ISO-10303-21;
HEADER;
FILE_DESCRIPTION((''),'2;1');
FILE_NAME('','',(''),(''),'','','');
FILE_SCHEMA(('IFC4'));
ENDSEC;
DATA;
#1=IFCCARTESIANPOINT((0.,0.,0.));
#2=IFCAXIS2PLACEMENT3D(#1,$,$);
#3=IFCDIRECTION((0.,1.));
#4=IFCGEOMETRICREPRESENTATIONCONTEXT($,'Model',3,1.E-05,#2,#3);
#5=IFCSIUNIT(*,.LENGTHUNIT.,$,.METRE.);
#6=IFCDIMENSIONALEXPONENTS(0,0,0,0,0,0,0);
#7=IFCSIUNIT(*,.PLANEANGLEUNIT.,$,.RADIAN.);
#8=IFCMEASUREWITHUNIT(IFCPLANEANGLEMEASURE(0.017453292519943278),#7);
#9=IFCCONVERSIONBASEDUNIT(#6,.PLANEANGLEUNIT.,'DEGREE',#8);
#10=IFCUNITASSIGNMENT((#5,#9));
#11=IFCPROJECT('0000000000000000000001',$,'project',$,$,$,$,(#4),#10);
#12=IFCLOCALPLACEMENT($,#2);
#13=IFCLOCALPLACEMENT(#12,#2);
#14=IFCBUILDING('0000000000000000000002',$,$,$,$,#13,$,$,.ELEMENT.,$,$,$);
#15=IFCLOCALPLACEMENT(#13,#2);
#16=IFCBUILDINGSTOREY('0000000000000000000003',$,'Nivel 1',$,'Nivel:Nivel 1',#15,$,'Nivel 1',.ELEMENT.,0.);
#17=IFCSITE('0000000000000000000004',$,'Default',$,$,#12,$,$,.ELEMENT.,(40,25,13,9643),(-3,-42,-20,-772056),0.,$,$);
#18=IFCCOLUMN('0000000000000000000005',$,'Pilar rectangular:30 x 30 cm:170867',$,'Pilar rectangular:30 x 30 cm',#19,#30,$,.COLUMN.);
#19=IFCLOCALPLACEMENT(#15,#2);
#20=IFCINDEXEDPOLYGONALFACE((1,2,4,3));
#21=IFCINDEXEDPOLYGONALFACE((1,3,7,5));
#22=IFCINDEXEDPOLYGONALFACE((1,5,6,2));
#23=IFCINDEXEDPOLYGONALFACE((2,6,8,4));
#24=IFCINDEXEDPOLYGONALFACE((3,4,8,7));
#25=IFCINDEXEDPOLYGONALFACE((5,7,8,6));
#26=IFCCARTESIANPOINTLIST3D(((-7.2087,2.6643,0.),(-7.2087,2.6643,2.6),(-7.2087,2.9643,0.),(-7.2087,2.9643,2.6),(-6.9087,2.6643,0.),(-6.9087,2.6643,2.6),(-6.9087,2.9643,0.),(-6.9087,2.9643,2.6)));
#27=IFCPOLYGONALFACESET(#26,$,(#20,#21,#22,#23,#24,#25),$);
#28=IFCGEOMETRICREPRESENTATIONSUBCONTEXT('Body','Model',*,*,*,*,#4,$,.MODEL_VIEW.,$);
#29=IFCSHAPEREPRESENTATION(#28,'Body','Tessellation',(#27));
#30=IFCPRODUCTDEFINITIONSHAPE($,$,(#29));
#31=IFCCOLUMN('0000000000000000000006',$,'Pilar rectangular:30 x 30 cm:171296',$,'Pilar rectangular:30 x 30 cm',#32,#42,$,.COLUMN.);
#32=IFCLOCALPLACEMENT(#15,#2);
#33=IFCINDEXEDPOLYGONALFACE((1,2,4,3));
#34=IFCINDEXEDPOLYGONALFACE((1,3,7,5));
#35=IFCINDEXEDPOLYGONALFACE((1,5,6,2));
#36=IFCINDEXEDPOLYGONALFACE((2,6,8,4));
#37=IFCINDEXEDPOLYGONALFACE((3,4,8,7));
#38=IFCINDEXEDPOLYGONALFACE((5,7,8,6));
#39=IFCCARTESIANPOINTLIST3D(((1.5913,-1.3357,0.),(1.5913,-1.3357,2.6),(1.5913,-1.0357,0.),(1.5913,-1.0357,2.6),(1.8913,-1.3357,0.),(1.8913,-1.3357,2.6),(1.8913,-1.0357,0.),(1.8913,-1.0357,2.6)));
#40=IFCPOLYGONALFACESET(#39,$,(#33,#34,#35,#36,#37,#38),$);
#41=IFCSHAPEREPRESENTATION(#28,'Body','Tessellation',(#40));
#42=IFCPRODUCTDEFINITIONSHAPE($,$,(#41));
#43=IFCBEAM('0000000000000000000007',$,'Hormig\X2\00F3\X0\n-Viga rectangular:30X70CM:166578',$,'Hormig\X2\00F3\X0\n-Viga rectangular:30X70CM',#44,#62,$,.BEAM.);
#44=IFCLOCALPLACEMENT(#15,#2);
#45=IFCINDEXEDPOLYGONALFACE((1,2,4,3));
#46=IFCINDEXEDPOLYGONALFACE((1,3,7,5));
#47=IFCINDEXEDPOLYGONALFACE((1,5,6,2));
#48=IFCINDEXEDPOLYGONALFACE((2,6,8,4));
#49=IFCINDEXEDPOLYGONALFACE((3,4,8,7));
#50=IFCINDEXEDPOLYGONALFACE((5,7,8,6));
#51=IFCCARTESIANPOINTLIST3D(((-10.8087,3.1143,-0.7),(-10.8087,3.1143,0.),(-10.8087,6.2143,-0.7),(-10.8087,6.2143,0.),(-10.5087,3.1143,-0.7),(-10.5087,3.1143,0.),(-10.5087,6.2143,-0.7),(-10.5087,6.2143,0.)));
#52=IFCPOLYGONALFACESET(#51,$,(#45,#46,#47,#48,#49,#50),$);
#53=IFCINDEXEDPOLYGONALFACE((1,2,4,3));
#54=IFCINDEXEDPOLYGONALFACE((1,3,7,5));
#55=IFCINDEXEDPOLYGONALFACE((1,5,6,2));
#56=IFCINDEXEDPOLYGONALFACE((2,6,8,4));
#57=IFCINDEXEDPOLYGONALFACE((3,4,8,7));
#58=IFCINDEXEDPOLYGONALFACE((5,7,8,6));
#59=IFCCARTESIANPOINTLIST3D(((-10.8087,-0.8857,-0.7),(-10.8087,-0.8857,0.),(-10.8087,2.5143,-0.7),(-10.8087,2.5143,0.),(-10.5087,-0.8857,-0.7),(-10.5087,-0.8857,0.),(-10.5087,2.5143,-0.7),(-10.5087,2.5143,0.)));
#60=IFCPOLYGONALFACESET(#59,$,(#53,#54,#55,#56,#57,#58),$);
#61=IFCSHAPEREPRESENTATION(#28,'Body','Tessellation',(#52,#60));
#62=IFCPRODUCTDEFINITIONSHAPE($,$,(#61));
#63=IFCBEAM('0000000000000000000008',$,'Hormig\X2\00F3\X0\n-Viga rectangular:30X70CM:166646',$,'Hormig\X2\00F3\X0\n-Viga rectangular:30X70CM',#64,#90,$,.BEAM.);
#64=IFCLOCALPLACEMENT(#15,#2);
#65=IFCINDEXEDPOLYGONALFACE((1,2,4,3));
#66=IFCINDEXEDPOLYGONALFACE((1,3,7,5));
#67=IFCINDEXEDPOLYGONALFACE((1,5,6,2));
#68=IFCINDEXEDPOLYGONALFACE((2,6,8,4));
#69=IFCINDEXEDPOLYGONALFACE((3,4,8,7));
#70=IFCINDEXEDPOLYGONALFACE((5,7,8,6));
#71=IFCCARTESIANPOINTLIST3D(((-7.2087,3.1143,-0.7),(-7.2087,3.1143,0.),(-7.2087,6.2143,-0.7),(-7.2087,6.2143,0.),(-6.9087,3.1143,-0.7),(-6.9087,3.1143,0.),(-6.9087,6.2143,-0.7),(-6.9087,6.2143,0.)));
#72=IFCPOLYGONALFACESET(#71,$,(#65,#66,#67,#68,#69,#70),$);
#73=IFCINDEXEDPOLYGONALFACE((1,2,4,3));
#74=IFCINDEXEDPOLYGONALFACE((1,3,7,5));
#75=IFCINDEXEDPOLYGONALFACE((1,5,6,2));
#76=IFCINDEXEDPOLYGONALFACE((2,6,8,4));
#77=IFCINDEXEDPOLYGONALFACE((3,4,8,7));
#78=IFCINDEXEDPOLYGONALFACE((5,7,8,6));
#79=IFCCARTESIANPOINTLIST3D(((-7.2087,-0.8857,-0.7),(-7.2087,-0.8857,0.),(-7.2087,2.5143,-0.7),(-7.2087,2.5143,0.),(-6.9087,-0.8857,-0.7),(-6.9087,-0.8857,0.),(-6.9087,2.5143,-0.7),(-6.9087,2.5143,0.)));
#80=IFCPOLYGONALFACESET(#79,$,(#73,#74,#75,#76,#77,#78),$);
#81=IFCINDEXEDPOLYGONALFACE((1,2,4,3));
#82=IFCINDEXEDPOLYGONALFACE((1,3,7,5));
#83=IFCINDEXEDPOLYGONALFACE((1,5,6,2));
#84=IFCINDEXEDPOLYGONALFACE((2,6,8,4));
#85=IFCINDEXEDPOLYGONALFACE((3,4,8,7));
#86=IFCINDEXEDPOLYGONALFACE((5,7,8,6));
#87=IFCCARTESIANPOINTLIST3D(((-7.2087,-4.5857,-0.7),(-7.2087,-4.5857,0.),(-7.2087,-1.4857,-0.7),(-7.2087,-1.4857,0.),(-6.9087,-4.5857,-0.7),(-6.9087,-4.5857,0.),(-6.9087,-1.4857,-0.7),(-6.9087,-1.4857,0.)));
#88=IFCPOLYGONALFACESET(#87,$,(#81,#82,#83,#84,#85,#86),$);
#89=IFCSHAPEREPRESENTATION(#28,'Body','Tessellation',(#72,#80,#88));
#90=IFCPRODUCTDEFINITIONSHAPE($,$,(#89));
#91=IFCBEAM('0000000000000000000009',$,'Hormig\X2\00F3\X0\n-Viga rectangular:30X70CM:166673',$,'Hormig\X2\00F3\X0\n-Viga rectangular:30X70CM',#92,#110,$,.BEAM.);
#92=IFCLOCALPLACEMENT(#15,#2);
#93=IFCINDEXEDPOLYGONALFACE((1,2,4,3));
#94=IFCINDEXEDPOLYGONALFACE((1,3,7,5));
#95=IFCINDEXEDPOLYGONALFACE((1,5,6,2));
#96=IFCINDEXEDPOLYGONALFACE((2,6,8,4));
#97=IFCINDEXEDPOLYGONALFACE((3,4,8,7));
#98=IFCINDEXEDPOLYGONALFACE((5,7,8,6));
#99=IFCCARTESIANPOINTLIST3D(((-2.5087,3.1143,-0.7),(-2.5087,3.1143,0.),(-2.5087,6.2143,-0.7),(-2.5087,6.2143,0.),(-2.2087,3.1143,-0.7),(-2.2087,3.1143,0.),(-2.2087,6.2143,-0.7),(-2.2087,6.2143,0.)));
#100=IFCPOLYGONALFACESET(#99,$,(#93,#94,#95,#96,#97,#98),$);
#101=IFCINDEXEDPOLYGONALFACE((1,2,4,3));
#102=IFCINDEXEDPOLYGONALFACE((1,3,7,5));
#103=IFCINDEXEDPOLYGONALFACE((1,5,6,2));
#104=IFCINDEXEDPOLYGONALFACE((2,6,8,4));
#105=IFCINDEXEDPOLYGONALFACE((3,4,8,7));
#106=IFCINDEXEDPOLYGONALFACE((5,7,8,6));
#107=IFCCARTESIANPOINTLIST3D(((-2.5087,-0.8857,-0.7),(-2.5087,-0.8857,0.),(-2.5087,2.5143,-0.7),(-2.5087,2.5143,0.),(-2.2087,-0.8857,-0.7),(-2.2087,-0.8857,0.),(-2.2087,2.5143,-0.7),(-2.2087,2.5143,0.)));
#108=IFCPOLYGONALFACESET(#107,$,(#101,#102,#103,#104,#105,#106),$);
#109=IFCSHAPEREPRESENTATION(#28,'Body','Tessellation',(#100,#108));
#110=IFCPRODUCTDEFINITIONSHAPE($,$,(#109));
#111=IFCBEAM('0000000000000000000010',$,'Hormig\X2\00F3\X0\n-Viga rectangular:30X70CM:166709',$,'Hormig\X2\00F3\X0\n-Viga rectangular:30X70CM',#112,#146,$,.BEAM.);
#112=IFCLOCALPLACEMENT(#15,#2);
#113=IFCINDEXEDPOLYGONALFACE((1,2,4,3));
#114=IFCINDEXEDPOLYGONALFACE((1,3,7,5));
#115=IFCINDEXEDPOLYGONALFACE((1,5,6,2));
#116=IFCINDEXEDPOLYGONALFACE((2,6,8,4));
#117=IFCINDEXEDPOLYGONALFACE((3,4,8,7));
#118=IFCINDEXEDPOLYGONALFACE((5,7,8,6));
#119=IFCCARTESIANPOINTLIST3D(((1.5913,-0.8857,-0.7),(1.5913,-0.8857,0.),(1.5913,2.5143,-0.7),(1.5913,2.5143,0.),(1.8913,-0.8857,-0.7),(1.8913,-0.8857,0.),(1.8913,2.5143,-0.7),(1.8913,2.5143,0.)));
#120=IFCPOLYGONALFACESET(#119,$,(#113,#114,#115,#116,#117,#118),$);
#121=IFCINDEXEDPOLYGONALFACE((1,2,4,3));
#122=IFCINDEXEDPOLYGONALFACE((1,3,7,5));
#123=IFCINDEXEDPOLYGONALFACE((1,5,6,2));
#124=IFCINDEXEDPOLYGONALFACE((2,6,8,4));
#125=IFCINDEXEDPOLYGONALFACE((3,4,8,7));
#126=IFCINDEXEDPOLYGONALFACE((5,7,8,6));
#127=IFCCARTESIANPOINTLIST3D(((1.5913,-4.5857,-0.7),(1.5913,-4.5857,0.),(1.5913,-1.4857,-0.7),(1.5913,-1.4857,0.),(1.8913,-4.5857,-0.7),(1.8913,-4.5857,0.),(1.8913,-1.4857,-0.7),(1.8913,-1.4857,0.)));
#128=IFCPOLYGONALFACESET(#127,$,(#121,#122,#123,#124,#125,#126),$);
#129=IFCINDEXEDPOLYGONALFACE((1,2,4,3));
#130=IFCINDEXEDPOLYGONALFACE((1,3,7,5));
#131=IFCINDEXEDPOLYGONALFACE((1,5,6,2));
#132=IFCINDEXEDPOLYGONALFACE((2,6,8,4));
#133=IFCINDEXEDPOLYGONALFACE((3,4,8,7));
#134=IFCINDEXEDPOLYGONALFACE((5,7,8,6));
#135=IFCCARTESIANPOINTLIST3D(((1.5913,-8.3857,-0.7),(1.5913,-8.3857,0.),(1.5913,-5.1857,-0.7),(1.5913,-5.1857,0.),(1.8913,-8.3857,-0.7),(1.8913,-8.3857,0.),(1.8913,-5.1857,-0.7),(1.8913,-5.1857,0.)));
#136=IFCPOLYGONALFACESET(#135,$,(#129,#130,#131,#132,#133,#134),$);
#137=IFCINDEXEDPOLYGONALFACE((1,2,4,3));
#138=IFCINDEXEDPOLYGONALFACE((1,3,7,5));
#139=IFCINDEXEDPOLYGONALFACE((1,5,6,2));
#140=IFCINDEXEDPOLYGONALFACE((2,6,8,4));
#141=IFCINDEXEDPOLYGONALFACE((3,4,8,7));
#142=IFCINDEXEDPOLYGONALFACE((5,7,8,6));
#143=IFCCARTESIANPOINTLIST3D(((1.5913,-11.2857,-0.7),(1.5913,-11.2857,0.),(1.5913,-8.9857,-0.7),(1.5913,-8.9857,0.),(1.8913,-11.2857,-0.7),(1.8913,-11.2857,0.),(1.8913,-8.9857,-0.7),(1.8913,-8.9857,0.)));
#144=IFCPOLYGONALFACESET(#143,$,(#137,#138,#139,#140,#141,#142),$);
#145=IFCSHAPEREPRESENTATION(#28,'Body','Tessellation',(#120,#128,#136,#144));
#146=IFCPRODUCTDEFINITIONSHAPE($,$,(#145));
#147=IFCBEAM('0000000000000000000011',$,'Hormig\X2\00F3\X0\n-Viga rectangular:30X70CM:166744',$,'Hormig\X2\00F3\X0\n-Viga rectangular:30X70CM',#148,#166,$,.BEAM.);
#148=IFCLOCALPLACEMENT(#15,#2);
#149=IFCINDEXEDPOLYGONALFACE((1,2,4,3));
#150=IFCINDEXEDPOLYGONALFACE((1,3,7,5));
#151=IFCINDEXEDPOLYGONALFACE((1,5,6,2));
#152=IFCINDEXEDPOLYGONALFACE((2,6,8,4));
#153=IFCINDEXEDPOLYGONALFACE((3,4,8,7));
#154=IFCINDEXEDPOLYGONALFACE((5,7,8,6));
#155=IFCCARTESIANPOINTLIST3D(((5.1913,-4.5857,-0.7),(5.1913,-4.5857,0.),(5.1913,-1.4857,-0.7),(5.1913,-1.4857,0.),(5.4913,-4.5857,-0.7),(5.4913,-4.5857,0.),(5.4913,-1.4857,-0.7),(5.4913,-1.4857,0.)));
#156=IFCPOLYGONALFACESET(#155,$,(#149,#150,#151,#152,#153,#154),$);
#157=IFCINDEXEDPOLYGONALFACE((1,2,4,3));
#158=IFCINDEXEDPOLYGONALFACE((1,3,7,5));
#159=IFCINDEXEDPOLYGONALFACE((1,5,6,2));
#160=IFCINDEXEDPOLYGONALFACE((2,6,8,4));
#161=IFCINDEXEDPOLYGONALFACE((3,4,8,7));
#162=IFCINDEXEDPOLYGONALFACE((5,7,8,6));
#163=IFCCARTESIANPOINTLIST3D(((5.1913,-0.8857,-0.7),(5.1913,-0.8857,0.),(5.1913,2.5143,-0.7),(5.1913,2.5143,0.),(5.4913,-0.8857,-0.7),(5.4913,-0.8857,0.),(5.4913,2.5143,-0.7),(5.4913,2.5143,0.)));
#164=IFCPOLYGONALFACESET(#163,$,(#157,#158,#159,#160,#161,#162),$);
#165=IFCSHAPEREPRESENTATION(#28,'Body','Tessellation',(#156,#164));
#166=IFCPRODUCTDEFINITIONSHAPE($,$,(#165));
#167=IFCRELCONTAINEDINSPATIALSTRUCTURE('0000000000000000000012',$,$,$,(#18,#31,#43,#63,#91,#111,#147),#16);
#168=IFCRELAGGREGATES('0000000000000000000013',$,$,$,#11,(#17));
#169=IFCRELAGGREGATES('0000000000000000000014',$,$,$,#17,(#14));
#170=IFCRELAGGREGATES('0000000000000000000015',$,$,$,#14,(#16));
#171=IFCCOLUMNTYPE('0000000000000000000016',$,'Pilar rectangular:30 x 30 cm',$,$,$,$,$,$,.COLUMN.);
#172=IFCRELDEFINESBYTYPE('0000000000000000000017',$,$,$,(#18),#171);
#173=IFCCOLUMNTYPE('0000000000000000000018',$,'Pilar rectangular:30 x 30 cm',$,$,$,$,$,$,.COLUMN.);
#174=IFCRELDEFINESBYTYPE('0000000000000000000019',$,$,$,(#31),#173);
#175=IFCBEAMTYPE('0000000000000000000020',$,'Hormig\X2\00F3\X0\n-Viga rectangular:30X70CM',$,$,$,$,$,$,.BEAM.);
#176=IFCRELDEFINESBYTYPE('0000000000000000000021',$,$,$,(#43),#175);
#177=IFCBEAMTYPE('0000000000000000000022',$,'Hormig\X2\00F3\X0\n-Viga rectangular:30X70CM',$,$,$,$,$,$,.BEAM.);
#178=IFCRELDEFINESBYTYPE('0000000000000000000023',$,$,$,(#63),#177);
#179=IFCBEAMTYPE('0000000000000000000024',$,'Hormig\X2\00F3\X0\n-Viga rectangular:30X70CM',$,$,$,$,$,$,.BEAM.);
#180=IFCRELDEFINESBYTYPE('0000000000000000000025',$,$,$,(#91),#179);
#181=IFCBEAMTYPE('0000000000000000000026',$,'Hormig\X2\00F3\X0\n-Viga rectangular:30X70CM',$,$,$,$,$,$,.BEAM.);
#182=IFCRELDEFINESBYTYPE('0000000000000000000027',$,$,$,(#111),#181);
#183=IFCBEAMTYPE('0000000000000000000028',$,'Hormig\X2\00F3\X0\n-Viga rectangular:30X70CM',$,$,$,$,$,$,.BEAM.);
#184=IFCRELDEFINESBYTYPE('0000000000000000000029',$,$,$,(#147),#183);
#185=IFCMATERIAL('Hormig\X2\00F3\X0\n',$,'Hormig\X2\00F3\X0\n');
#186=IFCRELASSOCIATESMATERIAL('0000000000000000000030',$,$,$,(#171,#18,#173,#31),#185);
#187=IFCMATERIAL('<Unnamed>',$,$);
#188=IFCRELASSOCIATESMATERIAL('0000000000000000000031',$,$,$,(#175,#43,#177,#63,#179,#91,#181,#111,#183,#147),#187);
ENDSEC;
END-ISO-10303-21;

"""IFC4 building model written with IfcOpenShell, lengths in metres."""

from ifc_helpers import new_model, entity, si_unit, converted_unit, direction, frame, origin, place, context, subcontext, project, spatial, indexed_curve, outline, extrude, source, transform, mapped, material, type_object, type_shapes, element, save


model = new_model("IFC4")

# Units and contexts
model_context = context("Model", 3, precision=1e-05, world=origin(), true_north=direction((0.0, 1.0)))
body_context = subcontext(model_context, "Body", "Model", "MODEL_VIEW")
ifc_project = project(units=[si_unit("LENGTHUNIT", "METRE"), converted_unit("PLANEANGLEUNIT", "DEGREE", entity("IfcPlaneAngleMeasure", 0.017453292519943278), si_unit("PLANEANGLEUNIT", "RADIAN"), dimensions=[0, 0, 0, 0, 0, 0, 0])], contexts=[model_context])

# Site, building, storey
site_placement = place(None, origin())
site = spatial("IfcSite", under=ifc_project, at=site_placement, Name="Default", CompositionType="ELEMENT", RefLatitude=(40, 25, 13, 9643), RefLongitude=(-3, -42, -20, -772056), RefElevation=0.0)
building_placement = place(site_placement, origin())
building = spatial("IfcBuilding", under=site, at=building_placement, CompositionType="ELEMENT")
storey_placement = place(building_placement, origin())
storey = spatial("IfcBuildingStorey", under=building, at=storey_placement, Name="Nivel 1", ObjectType="Nivel:Nivel 1", LongName="Nivel 1", CompositionType="ELEMENT", Elevation=0.0)

# Columns
ifc_material_1 = material(Name="Hormigón", Category="Hormigón")
column_type_1 = type_object("IfcColumnType", Name="Pilar rectangular:30 x 30 cm", PredefinedType="COLUMN", material=ifc_material_1)
shared_shape_1 = source(origin(), body_context, "Body", "SweptSolid", [
    extrude(outline(indexed_curve([(-0.15, -0.15), (0.15, -0.15), (0.15, 0.15), (-0.15, 0.15), (-0.15, -0.15)], self_intersect=False)), frame((-7.0587, 2.8143, 0.0), z_axis=(0.0, 0.0, 1.0), x_axis=(-1.0, 0.0, 0.0)), (0.0, 0.0, 1.0), 2.6),
])
type_shapes(column_type_1, [shared_shape_1])
column_1_placement = place(storey_placement, origin())
element("IfcColumn", 1, at=column_1_placement, inside=storey, type_object=column_type_1, material=ifc_material_1, Name="Pilar rectangular:30 x 30 cm:170867", ObjectType="Pilar rectangular:30 x 30 cm", PredefinedType="COLUMN", context=body_context, shape_type="MappedRepresentation", body=[
    mapped(shared_shape_1, transform((0.0, 0.0, 0.0), scale=1.0)),
])
column_type_2 = type_object("IfcColumnType", Name="Pilar rectangular:30 x 30 cm", PredefinedType="COLUMN", material=ifc_material_1)
shared_shape_2 = source(origin(), body_context, "Body", "SweptSolid", [
    extrude(outline(indexed_curve([(-0.15, -0.15), (0.15, -0.15), (0.15, 0.15), (-0.15, 0.15), (-0.15, -0.15)], self_intersect=False)), frame((1.7413, -1.1857, 0.0), z_axis=(0.0, 0.0, 1.0), x_axis=(-1.0, 0.0, 0.0)), (0.0, 0.0, 1.0), 2.6),
])
type_shapes(column_type_2, [shared_shape_2])
column_2_placement = place(storey_placement, origin())
element("IfcColumn", 2, at=column_2_placement, inside=storey, type_object=column_type_2, material=ifc_material_1, Name="Pilar rectangular:30 x 30 cm:171296", ObjectType="Pilar rectangular:30 x 30 cm", PredefinedType="COLUMN", context=body_context, shape_type="MappedRepresentation", body=[
    mapped(shared_shape_2, transform((0.0, 0.0, 0.0), scale=1.0)),
])

# Beams
ifc_material_2 = material(Name="<Unnamed>")
beam_type_1 = type_object("IfcBeamType", Name="Hormigón-Viga rectangular:30X70CM", PredefinedType="BEAM", material=ifc_material_2)
shared_shape_3 = source(origin(), body_context, "Body", "SweptSolid", [
    extrude(outline(indexed_curve([(-0.15, -0.35), (0.15, -0.35), (0.15, 0.35), (-0.15, 0.35), (-0.15, -0.35)], self_intersect=False)), frame((-10.6587, 6.2143, -0.35), z_axis=(0.0, -1.0, 0.0), x_axis=(-1.0, 0.0, 0.0)), (0.0, 0.0, 1.0), 3.1),
    extrude(outline(indexed_curve([(-0.15, -0.35), (0.15, -0.35), (0.15, 0.35), (-0.15, 0.35), (-0.15, -0.35)], self_intersect=False)), frame((-10.6587, 2.5143, -0.35), z_axis=(0.0, -1.0, 0.0), x_axis=(-1.0, 0.0, 0.0)), (0.0, 0.0, 1.0), 3.4),
])
type_shapes(beam_type_1, [shared_shape_3])
beam_1_placement = place(storey_placement, origin())
element("IfcBeam", 3, at=beam_1_placement, inside=storey, type_object=beam_type_1, material=ifc_material_2, Name="Hormigón-Viga rectangular:30X70CM:166578", ObjectType="Hormigón-Viga rectangular:30X70CM", PredefinedType="BEAM", context=body_context, shape_type="MappedRepresentation", body=[
    mapped(shared_shape_3, transform((0.0, 0.0, 0.0), scale=1.0)),
])
beam_type_2 = type_object("IfcBeamType", Name="Hormigón-Viga rectangular:30X70CM", PredefinedType="BEAM", material=ifc_material_2)
shared_shape_4 = source(origin(), body_context, "Body", "SweptSolid", [
    extrude(outline(indexed_curve([(-0.15, -0.35), (0.15, -0.35), (0.15, 0.35), (-0.15, 0.35), (-0.15, -0.35)], self_intersect=False)), frame((-7.0587, 6.2143, -0.35), z_axis=(0.0, -1.0, 0.0), x_axis=(-1.0, 0.0, 0.0)), (0.0, 0.0, 1.0), 3.1),
    extrude(outline(indexed_curve([(-0.15, -0.35), (0.15, -0.35), (0.15, 0.35), (-0.15, 0.35), (-0.15, -0.35)], self_intersect=False)), frame((-7.0587, 2.5143, -0.35), z_axis=(0.0, -1.0, 0.0), x_axis=(-1.0, 0.0, 0.0)), (0.0, 0.0, 1.0), 3.4),
    extrude(outline(indexed_curve([(-0.15, -0.35), (0.15, -0.35), (0.15, 0.35), (-0.15, 0.35), (-0.15, -0.35)], self_intersect=False)), frame((-7.0587, -1.4857, -0.35), z_axis=(0.0, -1.0, 0.0), x_axis=(-1.0, 0.0, 0.0)), (0.0, 0.0, 1.0), 3.1),
])
type_shapes(beam_type_2, [shared_shape_4])
beam_2_placement = place(storey_placement, origin())
element("IfcBeam", 4, at=beam_2_placement, inside=storey, type_object=beam_type_2, material=ifc_material_2, Name="Hormigón-Viga rectangular:30X70CM:166646", ObjectType="Hormigón-Viga rectangular:30X70CM", PredefinedType="BEAM", context=body_context, shape_type="MappedRepresentation", body=[
    mapped(shared_shape_4, transform((0.0, 0.0, 0.0), scale=1.0)),
])
beam_type_3 = type_object("IfcBeamType", Name="Hormigón-Viga rectangular:30X70CM", PredefinedType="BEAM", material=ifc_material_2)
shared_shape_5 = source(origin(), body_context, "Body", "SweptSolid", [
    extrude(outline(indexed_curve([(-0.15, -0.35), (0.15, -0.35), (0.15, 0.35), (-0.15, 0.35), (-0.15, -0.35)], self_intersect=False)), frame((-2.3587, 6.2143, -0.35), z_axis=(0.0, -1.0, 0.0), x_axis=(-1.0, 0.0, 0.0)), (0.0, 0.0, 1.0), 3.1),
    extrude(outline(indexed_curve([(-0.15, -0.35), (0.15, -0.35), (0.15, 0.35), (-0.15, 0.35), (-0.15, -0.35)], self_intersect=False)), frame((-2.3587, 2.5143, -0.35), z_axis=(0.0, -1.0, 0.0), x_axis=(-1.0, 0.0, 0.0)), (0.0, 0.0, 1.0), 3.4),
])
type_shapes(beam_type_3, [shared_shape_5])
beam_3_placement = place(storey_placement, origin())
element("IfcBeam", 5, at=beam_3_placement, inside=storey, type_object=beam_type_3, material=ifc_material_2, Name="Hormigón-Viga rectangular:30X70CM:166673", ObjectType="Hormigón-Viga rectangular:30X70CM", PredefinedType="BEAM", context=body_context, shape_type="MappedRepresentation", body=[
    mapped(shared_shape_5, transform((0.0, 0.0, 0.0), scale=1.0)),
])
beam_type_4 = type_object("IfcBeamType", Name="Hormigón-Viga rectangular:30X70CM", PredefinedType="BEAM", material=ifc_material_2)
shared_shape_6 = source(origin(), body_context, "Body", "SweptSolid", [
    extrude(outline(indexed_curve([(-0.15, -0.35), (0.15, -0.35), (0.15, 0.35), (-0.15, 0.35), (-0.15, -0.35)], self_intersect=False)), frame((1.7413, 2.5143, -0.35), z_axis=(0.0, -1.0, 0.0), x_axis=(-1.0, 0.0, 0.0)), (0.0, 0.0, 1.0), 3.4),
    extrude(outline(indexed_curve([(-0.15, -0.35), (0.15, -0.35), (0.15, 0.35), (-0.15, 0.35), (-0.15, -0.35)], self_intersect=False)), frame((1.7413, -1.4857, -0.35), z_axis=(0.0, -1.0, 0.0), x_axis=(-1.0, 0.0, 0.0)), (0.0, 0.0, 1.0), 3.1),
    extrude(outline(indexed_curve([(-0.15, -0.35), (0.15, -0.35), (0.15, 0.35), (-0.15, 0.35), (-0.15, -0.35)], self_intersect=False)), frame((1.7413, -5.1857, -0.35), z_axis=(0.0, -1.0, 0.0), x_axis=(-1.0, 0.0, 0.0)), (0.0, 0.0, 1.0), 3.2),
    extrude(outline(indexed_curve([(-0.15, -0.35), (0.15, -0.35), (0.15, 0.35), (-0.15, 0.35), (-0.15, -0.35)], self_intersect=False)), frame((1.7413, -8.9857, -0.35), z_axis=(0.0, -1.0, 0.0), x_axis=(-1.0, 0.0, 0.0)), (0.0, 0.0, 1.0), 2.3),
])
type_shapes(beam_type_4, [shared_shape_6])
beam_4_placement = place(storey_placement, origin())
element("IfcBeam", 6, at=beam_4_placement, inside=storey, type_object=beam_type_4, material=ifc_material_2, Name="Hormigón-Viga rectangular:30X70CM:166709", ObjectType="Hormigón-Viga rectangular:30X70CM", PredefinedType="BEAM", context=body_context, shape_type="MappedRepresentation", body=[
    mapped(shared_shape_6, transform((0.0, 0.0, 0.0), scale=1.0)),
])
beam_type_5 = type_object("IfcBeamType", Name="Hormigón-Viga rectangular:30X70CM", PredefinedType="BEAM", material=ifc_material_2)
shared_shape_7 = source(origin(), body_context, "Body", "SweptSolid", [
    extrude(outline(indexed_curve([(-0.15, -0.35), (0.15, -0.35), (0.15, 0.35), (-0.15, 0.35), (-0.15, -0.35)], self_intersect=False)), frame((5.3413, -1.4857, -0.35), z_axis=(0.0, -1.0, 0.0), x_axis=(-1.0, 0.0, 0.0)), (0.0, 0.0, 1.0), 3.1),
    extrude(outline(indexed_curve([(-0.15, -0.35), (0.15, -0.35), (0.15, 0.35), (-0.15, 0.35), (-0.15, -0.35)], self_intersect=False)), frame((5.3413, 2.5143, -0.35), z_axis=(0.0, -1.0, 0.0), x_axis=(-1.0, 0.0, 0.0)), (0.0, 0.0, 1.0), 3.4),
])
type_shapes(beam_type_5, [shared_shape_7])
beam_5_placement = place(storey_placement, origin())
element("IfcBeam", 7, at=beam_5_placement, inside=storey, type_object=beam_type_5, material=ifc_material_2, Name="Hormigón-Viga rectangular:30X70CM:166744", ObjectType="Hormigón-Viga rectangular:30X70CM", PredefinedType="BEAM", context=body_context, shape_type="MappedRepresentation", body=[
    mapped(shared_shape_7, transform((0.0, 0.0, 0.0), scale=1.0)),
])

save(model, "model.ifc")
